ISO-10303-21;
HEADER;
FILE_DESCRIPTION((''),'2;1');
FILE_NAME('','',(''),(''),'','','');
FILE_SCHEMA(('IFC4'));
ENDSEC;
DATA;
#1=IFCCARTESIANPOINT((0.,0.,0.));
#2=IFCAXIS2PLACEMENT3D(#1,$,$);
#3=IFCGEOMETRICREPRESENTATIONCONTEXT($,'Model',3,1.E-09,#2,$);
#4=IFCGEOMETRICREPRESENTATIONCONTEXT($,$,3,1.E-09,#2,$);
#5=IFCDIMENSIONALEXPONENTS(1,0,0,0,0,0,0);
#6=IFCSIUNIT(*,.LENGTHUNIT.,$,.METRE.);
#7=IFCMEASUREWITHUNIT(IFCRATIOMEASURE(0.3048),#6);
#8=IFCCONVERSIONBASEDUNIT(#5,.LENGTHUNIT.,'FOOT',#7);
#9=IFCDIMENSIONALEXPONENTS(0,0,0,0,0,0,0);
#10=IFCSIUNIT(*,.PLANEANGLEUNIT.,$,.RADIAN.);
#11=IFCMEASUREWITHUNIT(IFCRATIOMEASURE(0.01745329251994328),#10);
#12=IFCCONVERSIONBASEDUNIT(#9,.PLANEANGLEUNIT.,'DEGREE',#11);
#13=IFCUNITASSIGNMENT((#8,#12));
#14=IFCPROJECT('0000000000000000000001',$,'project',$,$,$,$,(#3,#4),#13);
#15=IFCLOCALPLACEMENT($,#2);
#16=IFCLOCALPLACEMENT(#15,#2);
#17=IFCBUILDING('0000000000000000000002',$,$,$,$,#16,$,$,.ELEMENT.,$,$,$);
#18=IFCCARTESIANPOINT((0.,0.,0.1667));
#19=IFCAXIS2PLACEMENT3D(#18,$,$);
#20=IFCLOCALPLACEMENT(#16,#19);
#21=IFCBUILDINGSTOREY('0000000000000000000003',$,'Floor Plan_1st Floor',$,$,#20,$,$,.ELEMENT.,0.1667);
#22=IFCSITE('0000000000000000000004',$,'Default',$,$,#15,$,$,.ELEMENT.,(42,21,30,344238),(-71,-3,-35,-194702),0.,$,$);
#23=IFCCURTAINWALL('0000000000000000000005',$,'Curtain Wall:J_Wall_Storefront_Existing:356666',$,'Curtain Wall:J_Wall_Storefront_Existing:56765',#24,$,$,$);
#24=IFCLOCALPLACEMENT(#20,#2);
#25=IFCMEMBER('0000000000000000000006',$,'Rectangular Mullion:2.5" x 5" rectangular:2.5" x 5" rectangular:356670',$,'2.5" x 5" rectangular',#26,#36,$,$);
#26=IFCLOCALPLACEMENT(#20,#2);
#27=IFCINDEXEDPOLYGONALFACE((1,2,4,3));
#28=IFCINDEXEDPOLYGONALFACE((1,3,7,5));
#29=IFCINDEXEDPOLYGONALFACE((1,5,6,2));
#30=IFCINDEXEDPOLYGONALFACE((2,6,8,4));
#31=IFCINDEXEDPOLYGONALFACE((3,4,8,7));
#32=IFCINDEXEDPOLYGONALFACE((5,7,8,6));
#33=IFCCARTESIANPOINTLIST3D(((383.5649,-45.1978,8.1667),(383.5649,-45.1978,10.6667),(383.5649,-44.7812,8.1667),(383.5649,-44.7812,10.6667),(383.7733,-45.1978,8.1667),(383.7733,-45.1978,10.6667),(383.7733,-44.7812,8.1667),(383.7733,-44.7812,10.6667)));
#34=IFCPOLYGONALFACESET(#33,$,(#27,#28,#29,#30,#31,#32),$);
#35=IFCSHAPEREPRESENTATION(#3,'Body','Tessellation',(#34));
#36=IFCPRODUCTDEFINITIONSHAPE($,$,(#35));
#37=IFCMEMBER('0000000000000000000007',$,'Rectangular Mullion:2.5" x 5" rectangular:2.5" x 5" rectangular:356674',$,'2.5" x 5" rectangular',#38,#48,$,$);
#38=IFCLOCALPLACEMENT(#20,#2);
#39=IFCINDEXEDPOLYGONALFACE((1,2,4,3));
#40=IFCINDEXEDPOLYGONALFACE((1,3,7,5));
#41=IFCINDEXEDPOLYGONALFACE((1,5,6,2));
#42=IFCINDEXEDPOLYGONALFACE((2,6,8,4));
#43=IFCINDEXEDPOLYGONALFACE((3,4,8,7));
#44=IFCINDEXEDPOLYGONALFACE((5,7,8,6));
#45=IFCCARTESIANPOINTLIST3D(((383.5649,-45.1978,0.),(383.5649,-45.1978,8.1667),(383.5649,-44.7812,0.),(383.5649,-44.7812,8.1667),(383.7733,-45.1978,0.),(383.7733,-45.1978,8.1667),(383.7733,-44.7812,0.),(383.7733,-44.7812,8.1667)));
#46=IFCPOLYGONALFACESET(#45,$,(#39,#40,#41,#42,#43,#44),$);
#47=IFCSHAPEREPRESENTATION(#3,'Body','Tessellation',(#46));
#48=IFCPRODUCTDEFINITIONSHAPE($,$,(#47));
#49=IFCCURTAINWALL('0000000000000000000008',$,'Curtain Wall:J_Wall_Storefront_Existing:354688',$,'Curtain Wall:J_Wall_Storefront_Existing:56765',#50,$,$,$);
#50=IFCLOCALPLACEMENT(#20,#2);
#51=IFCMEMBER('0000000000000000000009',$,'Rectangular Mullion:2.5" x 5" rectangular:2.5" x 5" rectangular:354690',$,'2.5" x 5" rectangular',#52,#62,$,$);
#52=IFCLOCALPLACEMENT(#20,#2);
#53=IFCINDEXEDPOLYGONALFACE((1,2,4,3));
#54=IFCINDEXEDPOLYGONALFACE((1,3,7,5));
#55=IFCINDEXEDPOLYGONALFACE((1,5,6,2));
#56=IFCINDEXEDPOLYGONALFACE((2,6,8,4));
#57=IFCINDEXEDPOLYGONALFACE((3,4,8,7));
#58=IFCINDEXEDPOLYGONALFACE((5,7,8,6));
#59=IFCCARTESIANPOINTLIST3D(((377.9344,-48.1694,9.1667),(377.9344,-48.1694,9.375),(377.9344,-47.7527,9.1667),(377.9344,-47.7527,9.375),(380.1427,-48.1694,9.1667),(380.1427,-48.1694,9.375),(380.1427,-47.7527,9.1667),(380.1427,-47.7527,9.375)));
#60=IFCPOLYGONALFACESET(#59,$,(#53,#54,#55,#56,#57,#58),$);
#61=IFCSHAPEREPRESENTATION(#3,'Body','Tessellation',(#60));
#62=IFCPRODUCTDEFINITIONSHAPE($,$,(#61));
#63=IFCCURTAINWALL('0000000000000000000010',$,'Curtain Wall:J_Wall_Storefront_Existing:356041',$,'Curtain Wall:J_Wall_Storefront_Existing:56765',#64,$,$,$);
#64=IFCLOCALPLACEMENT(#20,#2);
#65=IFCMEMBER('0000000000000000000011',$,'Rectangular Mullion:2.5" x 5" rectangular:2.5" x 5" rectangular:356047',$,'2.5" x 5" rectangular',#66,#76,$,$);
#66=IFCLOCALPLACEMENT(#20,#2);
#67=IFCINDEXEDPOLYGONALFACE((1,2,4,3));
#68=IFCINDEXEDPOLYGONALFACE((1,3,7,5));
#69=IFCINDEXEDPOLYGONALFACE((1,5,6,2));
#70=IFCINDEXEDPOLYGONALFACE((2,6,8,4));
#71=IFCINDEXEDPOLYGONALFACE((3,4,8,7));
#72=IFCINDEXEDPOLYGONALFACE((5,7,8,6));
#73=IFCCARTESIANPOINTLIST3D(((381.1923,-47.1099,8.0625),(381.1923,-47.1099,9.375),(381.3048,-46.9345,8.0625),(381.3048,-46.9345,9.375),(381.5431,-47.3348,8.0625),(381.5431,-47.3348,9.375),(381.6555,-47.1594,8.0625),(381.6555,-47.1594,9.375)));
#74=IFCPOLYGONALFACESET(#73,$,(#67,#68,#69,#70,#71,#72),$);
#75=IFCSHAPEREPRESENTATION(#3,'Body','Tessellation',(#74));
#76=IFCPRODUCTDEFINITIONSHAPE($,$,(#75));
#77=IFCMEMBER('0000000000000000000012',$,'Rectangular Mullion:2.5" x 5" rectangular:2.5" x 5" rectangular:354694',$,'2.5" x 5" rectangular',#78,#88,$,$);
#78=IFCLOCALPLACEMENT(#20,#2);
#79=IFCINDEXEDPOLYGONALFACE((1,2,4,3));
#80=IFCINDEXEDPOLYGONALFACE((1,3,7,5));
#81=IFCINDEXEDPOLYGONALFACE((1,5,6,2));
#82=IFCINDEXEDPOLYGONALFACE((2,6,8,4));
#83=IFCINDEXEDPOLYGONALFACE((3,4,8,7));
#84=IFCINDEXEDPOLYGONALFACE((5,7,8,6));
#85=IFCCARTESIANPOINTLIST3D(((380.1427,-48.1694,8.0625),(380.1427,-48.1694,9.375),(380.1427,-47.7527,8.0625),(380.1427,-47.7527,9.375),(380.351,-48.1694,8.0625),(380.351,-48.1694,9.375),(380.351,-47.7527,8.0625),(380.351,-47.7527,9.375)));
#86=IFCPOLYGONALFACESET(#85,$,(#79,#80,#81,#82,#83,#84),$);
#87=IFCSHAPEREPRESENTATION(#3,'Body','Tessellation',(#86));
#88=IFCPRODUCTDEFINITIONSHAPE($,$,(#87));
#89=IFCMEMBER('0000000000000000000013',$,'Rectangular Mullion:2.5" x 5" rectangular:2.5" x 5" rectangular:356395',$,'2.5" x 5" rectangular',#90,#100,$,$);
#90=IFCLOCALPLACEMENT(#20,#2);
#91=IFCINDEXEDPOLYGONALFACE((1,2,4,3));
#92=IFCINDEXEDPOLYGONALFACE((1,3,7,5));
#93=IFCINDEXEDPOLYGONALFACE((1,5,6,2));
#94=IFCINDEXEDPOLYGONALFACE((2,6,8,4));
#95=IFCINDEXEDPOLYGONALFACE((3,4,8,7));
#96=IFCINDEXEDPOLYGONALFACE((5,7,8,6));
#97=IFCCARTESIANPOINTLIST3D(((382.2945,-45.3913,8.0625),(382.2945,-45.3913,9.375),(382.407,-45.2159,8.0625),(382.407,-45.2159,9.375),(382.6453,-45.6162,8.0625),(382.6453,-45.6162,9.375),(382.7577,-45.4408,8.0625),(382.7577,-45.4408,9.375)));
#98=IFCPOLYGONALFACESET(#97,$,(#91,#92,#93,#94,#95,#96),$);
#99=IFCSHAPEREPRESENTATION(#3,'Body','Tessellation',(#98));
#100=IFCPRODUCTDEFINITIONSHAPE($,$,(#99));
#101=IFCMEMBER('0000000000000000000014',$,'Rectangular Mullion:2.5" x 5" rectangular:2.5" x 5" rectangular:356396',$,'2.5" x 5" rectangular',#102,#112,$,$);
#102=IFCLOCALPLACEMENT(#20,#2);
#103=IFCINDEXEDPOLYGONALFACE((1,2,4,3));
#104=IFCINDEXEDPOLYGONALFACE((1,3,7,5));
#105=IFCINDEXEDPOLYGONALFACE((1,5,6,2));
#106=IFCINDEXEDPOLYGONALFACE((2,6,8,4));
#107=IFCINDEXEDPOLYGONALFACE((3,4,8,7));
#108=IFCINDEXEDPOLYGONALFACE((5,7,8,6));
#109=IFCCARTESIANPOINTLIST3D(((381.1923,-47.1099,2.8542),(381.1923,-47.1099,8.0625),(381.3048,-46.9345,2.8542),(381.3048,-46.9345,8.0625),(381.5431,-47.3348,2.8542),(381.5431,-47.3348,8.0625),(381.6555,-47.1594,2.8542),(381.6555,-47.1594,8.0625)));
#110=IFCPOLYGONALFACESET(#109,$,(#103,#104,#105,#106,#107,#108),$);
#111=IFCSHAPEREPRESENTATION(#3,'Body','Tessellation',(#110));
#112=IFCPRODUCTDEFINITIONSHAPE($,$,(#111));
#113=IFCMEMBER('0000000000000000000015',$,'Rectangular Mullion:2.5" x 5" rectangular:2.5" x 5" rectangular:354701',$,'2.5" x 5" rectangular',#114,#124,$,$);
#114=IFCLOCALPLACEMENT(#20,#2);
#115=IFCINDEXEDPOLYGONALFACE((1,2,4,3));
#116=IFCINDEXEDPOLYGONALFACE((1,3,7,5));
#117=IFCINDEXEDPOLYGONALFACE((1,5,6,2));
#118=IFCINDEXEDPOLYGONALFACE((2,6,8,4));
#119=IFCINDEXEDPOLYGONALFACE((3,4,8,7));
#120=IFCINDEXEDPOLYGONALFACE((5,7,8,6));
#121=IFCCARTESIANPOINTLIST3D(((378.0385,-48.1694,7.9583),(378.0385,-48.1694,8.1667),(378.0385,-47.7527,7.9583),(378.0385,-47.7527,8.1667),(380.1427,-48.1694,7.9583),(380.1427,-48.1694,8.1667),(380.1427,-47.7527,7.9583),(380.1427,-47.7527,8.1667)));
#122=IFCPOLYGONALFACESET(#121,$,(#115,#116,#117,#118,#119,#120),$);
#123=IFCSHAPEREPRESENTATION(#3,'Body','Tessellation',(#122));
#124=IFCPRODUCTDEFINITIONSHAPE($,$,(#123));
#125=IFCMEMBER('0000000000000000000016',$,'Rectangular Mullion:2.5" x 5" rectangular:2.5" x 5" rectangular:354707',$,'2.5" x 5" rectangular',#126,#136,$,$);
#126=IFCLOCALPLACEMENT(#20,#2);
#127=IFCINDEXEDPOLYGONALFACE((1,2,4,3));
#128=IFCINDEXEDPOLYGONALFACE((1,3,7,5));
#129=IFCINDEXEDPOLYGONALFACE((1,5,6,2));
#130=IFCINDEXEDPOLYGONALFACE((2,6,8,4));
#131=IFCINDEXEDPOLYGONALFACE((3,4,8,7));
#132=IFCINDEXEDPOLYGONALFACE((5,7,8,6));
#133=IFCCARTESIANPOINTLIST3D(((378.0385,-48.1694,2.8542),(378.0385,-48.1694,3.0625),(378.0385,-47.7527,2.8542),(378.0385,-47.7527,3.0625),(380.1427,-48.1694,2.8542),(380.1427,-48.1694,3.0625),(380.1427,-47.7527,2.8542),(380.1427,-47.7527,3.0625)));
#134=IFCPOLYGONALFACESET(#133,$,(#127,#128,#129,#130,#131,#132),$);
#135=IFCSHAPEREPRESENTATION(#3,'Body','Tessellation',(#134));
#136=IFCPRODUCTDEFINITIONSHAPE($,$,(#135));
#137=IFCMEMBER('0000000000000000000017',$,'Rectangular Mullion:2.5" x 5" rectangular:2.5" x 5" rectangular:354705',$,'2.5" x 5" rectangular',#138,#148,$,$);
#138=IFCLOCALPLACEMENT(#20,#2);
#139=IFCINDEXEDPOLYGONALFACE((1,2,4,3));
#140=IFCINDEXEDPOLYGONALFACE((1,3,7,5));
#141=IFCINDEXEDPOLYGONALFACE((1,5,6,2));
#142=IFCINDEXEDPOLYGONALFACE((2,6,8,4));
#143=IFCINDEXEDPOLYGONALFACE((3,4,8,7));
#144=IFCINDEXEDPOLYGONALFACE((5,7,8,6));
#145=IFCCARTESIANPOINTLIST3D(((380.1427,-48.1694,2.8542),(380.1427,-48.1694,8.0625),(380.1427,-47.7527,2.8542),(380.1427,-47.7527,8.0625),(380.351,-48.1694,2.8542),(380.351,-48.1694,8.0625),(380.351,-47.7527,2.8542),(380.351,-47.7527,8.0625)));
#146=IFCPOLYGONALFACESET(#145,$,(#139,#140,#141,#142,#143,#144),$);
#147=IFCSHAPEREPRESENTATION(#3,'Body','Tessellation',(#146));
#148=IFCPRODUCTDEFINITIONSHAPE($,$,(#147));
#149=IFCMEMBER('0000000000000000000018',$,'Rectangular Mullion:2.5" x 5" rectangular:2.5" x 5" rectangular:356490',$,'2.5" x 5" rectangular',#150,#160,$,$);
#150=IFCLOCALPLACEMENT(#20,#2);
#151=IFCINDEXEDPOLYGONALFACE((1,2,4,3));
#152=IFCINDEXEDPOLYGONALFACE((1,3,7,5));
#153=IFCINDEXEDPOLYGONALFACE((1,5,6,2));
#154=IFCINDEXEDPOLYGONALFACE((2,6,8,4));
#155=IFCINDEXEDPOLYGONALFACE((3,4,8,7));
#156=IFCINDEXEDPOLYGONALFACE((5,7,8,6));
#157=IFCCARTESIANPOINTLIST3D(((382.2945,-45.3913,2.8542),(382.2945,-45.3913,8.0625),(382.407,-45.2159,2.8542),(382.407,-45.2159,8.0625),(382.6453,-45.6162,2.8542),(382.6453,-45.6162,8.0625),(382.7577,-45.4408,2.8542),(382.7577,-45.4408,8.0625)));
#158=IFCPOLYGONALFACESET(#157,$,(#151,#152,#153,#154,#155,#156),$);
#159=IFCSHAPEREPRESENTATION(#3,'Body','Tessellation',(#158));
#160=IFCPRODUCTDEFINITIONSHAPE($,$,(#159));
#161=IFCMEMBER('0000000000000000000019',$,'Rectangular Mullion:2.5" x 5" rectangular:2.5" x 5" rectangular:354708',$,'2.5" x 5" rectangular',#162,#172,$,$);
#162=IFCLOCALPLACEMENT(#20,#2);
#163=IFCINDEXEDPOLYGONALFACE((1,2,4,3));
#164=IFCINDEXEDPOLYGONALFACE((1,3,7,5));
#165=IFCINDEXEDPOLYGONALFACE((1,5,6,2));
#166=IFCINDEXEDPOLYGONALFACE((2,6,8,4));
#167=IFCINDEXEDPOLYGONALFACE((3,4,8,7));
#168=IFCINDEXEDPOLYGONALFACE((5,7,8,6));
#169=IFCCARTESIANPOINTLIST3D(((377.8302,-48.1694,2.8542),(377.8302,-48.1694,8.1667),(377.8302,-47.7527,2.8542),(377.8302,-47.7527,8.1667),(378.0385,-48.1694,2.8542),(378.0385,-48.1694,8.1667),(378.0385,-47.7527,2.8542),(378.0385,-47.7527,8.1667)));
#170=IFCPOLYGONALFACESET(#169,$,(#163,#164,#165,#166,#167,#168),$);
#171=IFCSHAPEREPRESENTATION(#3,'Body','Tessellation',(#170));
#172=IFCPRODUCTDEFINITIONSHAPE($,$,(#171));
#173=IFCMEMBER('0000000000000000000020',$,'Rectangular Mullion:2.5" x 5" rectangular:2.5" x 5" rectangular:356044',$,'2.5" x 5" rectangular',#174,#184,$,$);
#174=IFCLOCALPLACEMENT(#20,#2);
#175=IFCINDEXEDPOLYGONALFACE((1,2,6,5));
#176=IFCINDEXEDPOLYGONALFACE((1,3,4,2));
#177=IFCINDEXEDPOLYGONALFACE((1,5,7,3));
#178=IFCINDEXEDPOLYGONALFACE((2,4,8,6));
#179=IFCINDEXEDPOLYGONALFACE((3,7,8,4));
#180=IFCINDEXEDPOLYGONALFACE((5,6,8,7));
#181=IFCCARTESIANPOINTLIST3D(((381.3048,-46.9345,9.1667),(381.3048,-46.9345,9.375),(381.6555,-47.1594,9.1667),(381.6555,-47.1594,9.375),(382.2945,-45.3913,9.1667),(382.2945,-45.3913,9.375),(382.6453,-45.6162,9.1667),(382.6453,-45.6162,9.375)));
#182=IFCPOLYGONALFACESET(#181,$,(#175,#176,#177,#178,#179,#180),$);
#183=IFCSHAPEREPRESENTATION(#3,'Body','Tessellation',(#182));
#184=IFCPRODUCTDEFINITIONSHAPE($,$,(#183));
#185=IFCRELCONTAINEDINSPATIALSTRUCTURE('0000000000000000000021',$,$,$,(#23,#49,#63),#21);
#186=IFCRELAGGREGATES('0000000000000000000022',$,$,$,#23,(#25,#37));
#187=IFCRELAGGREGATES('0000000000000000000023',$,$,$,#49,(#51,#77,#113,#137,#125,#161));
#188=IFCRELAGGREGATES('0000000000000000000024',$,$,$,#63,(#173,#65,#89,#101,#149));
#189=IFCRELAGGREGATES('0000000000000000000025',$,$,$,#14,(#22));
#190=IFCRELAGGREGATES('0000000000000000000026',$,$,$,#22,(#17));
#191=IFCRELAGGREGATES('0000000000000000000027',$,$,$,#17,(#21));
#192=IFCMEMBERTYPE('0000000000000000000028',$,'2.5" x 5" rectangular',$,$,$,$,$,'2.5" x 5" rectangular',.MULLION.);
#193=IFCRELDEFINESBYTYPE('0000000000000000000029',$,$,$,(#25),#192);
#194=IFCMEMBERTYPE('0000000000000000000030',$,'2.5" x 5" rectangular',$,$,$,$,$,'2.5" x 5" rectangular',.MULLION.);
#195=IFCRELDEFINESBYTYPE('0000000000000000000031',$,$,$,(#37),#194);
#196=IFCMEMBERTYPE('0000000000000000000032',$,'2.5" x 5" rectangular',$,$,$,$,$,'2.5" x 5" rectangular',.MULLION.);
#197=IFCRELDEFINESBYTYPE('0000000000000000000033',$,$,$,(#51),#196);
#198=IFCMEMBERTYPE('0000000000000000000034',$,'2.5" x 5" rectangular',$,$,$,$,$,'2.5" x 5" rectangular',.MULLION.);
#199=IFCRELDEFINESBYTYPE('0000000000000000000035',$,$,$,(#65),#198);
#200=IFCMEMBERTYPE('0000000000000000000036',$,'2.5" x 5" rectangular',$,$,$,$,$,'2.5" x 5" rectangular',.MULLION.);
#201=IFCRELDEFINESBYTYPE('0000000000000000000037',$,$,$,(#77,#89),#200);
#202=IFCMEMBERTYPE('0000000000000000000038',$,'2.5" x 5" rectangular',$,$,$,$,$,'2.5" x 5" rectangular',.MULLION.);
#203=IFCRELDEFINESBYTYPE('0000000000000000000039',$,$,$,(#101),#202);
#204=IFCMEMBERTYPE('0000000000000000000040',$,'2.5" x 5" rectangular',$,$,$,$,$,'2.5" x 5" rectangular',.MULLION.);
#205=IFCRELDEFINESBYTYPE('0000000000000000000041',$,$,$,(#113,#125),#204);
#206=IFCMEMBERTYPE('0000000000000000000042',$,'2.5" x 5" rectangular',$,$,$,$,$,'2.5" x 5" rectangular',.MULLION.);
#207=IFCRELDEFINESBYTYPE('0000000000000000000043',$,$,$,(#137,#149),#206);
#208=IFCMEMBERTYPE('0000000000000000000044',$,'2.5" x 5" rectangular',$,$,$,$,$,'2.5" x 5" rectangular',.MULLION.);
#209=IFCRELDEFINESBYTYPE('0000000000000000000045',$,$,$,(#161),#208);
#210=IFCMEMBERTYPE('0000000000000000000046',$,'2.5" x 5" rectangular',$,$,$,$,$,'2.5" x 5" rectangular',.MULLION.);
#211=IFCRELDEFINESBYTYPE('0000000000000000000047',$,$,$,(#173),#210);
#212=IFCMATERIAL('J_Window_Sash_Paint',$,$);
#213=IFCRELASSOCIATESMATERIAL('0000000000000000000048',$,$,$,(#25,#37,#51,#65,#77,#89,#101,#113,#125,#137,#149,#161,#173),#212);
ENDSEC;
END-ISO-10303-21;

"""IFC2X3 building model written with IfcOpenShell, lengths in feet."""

from ifc_helpers import new_model, entity, si_unit, converted_unit, frame, origin, origin_2d_with_axis, place, context, project, spatial, rectangle, extrude, source, transform, mapped, material, type_object, type_shapes, element, aggregate, save


model = new_model("IFC2X3")

# Units and contexts
model_context = context("Model", 3, precision=1e-09, world=origin())
context_of_model = context(None, 3, precision=1e-09, world=origin())
ifc_project = project(units=[converted_unit("LENGTHUNIT", "FOOT", entity("IfcRatioMeasure", 0.3048), si_unit("LENGTHUNIT", "METRE"), dimensions=[1, 0, 0, 0, 0, 0, 0]), converted_unit("PLANEANGLEUNIT", "DEGREE", entity("IfcRatioMeasure", 0.01745329251994328), si_unit("PLANEANGLEUNIT", "RADIAN"), dimensions=[0, 0, 0, 0, 0, 0, 0])], contexts=[model_context, context_of_model])

# Site, building, storey
site_placement = place(None, origin())
site = spatial("IfcSite", under=ifc_project, at=site_placement, Name="Default", CompositionType="ELEMENT", RefLatitude=(42, 21, 30, 344238), RefLongitude=(-71, -3, -35, -194702), RefElevation=0.0)
building_placement = place(site_placement, origin())
building = spatial("IfcBuilding", under=site, at=building_placement, CompositionType="ELEMENT")
storey_placement = place(building_placement, frame((0.0, 0.0, 0.1667)))
storey = spatial("IfcBuildingStorey", under=building, at=storey_placement, Name="Floor Plan_1st Floor", CompositionType="ELEMENT", Elevation=0.1667)

# Curtain wall, members
curtain_wall_1_placement = place(storey_placement, origin())
curtain_wall_1 = element("IfcCurtainWall", 1, at=curtain_wall_1_placement, inside=storey, Name="Curtain Wall:J_Wall_Storefront_Existing:356666", ObjectType="Curtain Wall:J_Wall_Storefront_Existing:56765")
ifc_material_1 = material(Name="J_Window_Sash_Paint")
member_type_1 = type_object("IfcMemberType", Name="2.5\" x 5\" rectangular", ElementType="2.5\" x 5\" rectangular", PredefinedType="MULLION")
shared_shape_1 = source(origin(), model_context, "Body", "SweptSolid", [
    extrude(rectangle(XDim=0.2083, YDim=0.4167, at=origin_2d_with_axis()), frame((-0.1042, 0.0, -2.5), z_axis=(0.0, 0.0, 1.0), x_axis=(-1.0, 0.0, 0.0)), (0.0, 0.0, 1.0), 2.5),
])
type_shapes(member_type_1, [shared_shape_1])
member_1_placement = place(storey_placement, frame((383.5649, -44.9895, 10.6667), z_axis=(0.0, 0.0, 1.0), x_axis=(-1.0, 0.0, 0.0)))
member_1 = element("IfcMember", 2, at=member_1_placement, type_object=member_type_1, material=ifc_material_1, Name="Rectangular Mullion:2.5\" x 5\" rectangular:2.5\" x 5\" rectangular:356670", ObjectType="2.5\" x 5\" rectangular", context=model_context, shape_type="MappedRepresentation", body=[
    mapped(shared_shape_1, transform((0.0, 0.0, 0.0), scale=1.0)),
])
member_type_2 = type_object("IfcMemberType", Name="2.5\" x 5\" rectangular", ElementType="2.5\" x 5\" rectangular", PredefinedType="MULLION")
shared_shape_2 = source(origin(), model_context, "Body", "SweptSolid", [
    extrude(rectangle(XDim=0.2083, YDim=0.4167, at=origin_2d_with_axis()), frame((-0.1042, 0.0, -8.1667), z_axis=(0.0, 0.0, 1.0), x_axis=(-1.0, 0.0, 0.0)), (0.0, 0.0, 1.0), 8.1667),
])
type_shapes(member_type_2, [shared_shape_2])
member_2_placement = place(storey_placement, frame((383.5649, -44.9895, 8.1667), z_axis=(0.0, 0.0, 1.0), x_axis=(-1.0, 0.0, 0.0)))
member_2 = element("IfcMember", 3, at=member_2_placement, type_object=member_type_2, material=ifc_material_1, Name="Rectangular Mullion:2.5\" x 5\" rectangular:2.5\" x 5\" rectangular:356674", ObjectType="2.5\" x 5\" rectangular", context=model_context, shape_type="MappedRepresentation", body=[
    mapped(shared_shape_2, transform((0.0, 0.0, 0.0), scale=1.0)),
])
aggregate(curtain_wall_1, [member_1, member_2])

# Curtain walls, members
curtain_wall_2_placement = place(storey_placement, origin())
curtain_wall_2 = element("IfcCurtainWall", 4, at=curtain_wall_2_placement, inside=storey, Name="Curtain Wall:J_Wall_Storefront_Existing:354688", ObjectType="Curtain Wall:J_Wall_Storefront_Existing:56765")
member_type_3 = type_object("IfcMemberType", Name="2.5\" x 5\" rectangular", ElementType="2.5\" x 5\" rectangular", PredefinedType="MULLION")
shared_shape_3 = source(origin(), model_context, "Body", "SweptSolid", [
    extrude(rectangle(XDim=0.2083, YDim=0.4167, at=origin_2d_with_axis()), frame((-0.1042, 0.0, -2.2083), z_axis=(0.0, 0.0, 1.0), x_axis=(-1.0, 0.0, 0.0)), (0.0, 0.0, 1.0), 2.2083),
])
type_shapes(member_type_3, [shared_shape_3])
member_3_placement = place(storey_placement, frame((380.1427, -47.9611, 9.375), z_axis=(1.0, 0.0, 0.0), x_axis=(0.0, 0.0, 1.0)))
member_3 = element("IfcMember", 5, at=member_3_placement, type_object=member_type_3, material=ifc_material_1, Name="Rectangular Mullion:2.5\" x 5\" rectangular:2.5\" x 5\" rectangular:354690", ObjectType="2.5\" x 5\" rectangular", context=model_context, shape_type="MappedRepresentation", body=[
    mapped(shared_shape_3, transform((0.0, 0.0, 0.0), scale=1.0)),
])
curtain_wall_3_placement = place(storey_placement, origin())
curtain_wall_3 = element("IfcCurtainWall", 6, at=curtain_wall_3_placement, inside=storey, Name="Curtain Wall:J_Wall_Storefront_Existing:356041", ObjectType="Curtain Wall:J_Wall_Storefront_Existing:56765")
member_type_4 = type_object("IfcMemberType", Name="2.5\" x 5\" rectangular", ElementType="2.5\" x 5\" rectangular", PredefinedType="MULLION")
shared_shape_4 = source(origin(), model_context, "Body", "SweptSolid", [
    extrude(rectangle(XDim=0.2083, YDim=0.4167, at=origin_2d_with_axis()), frame((-0.1042, 0.0, -1.3125), z_axis=(0.0, 0.0, 1.0), x_axis=(-1.0, 0.0, 0.0)), (0.0, 0.0, 1.0), 1.3125),
])
type_shapes(member_type_4, [shared_shape_4])
member_4_placement = place(storey_placement, frame((381.3677, -47.2223, 9.375), z_axis=(0.0, 0.0, 1.0), x_axis=(-0.539846, -0.841764, 0.0)))
member_4 = element("IfcMember", 7, at=member_4_placement, type_object=member_type_4, material=ifc_material_1, Name="Rectangular Mullion:2.5\" x 5\" rectangular:2.5\" x 5\" rectangular:356047", ObjectType="2.5\" x 5\" rectangular", context=model_context, shape_type="MappedRepresentation", body=[
    mapped(shared_shape_4, transform((0.0, 0.0, 0.0), scale=1.0)),
])

# Members
member_type_5 = type_object("IfcMemberType", Name="2.5\" x 5\" rectangular", ElementType="2.5\" x 5\" rectangular", PredefinedType="MULLION")
shared_shape_5 = source(origin(), model_context, "Body", "SweptSolid", [
    extrude(rectangle(XDim=0.2083, YDim=0.4167, at=origin_2d_with_axis()), frame((-0.1042, 0.0, -1.3125), z_axis=(0.0, 0.0, 1.0), x_axis=(-1.0, 0.0, 0.0)), (0.0, 0.0, 1.0), 1.3125),
])
type_shapes(member_type_5, [shared_shape_5])
member_5_placement = place(storey_placement, frame((380.351, -47.9611, 8.0625), z_axis=(0.0, 0.0, -1.0), x_axis=(1.0, 0.0, 0.0)))
member_5 = element("IfcMember", 8, at=member_5_placement, type_object=member_type_5, material=ifc_material_1, Name="Rectangular Mullion:2.5\" x 5\" rectangular:2.5\" x 5\" rectangular:354694", ObjectType="2.5\" x 5\" rectangular", context=model_context, shape_type="MappedRepresentation", body=[
    mapped(shared_shape_5, transform((0.0, 0.0, 0.0), scale=1.0)),
])
member_6_placement = place(storey_placement, frame((382.5824, -45.3284, 8.0625), z_axis=(0.0, 0.0, -1.0), x_axis=(0.539846, 0.841764, 0.0)))
member_6 = element("IfcMember", 9, at=member_6_placement, type_object=member_type_5, material=ifc_material_1, Name="Rectangular Mullion:2.5\" x 5\" rectangular:2.5\" x 5\" rectangular:356395", ObjectType="2.5\" x 5\" rectangular", context=model_context, shape_type="MappedRepresentation", body=[
    mapped(shared_shape_5, transform((0.0, 0.0, 0.0), scale=1.0)),
])
member_type_6 = type_object("IfcMemberType", Name="2.5\" x 5\" rectangular", ElementType="2.5\" x 5\" rectangular", PredefinedType="MULLION")
shared_shape_6 = source(origin(), model_context, "Body", "SweptSolid", [
    extrude(rectangle(XDim=0.2083, YDim=0.4167, at=origin_2d_with_axis()), frame((-0.1042, 0.0, -5.2083), z_axis=(0.0, 0.0, 1.0), x_axis=(-1.0, 0.0, 0.0)), (0.0, 0.0, 1.0), 5.2083),
])
type_shapes(member_type_6, [shared_shape_6])
member_7_placement = place(storey_placement, frame((381.3677, -47.2223, 8.0625), z_axis=(0.0, 0.0, 1.0), x_axis=(-0.539846, -0.841764, 0.0)))
member_7 = element("IfcMember", 10, at=member_7_placement, type_object=member_type_6, material=ifc_material_1, Name="Rectangular Mullion:2.5\" x 5\" rectangular:2.5\" x 5\" rectangular:356396", ObjectType="2.5\" x 5\" rectangular", context=model_context, shape_type="MappedRepresentation", body=[
    mapped(shared_shape_6, transform((0.0, 0.0, 0.0), scale=1.0)),
])
member_type_7 = type_object("IfcMemberType", Name="2.5\" x 5\" rectangular", ElementType="2.5\" x 5\" rectangular", PredefinedType="MULLION")
shared_shape_7 = source(origin(), model_context, "Body", "SweptSolid", [
    extrude(rectangle(XDim=0.2083, YDim=0.4167, at=origin_2d_with_axis()), frame((0.0, 0.0, -2.1042), z_axis=(0.0, 0.0, 1.0), x_axis=(-1.0, 0.0, 0.0)), (0.0, 0.0, 1.0), 2.1042),
])
type_shapes(member_type_7, [shared_shape_7])
member_8_placement = place(storey_placement, frame((380.1427, -47.9611, 8.0625), z_axis=(1.0, 0.0, 0.0), x_axis=(0.0, 0.0, 1.0)))
member_8 = element("IfcMember", 11, at=member_8_placement, type_object=member_type_7, material=ifc_material_1, Name="Rectangular Mullion:2.5\" x 5\" rectangular:2.5\" x 5\" rectangular:354701", ObjectType="2.5\" x 5\" rectangular", context=model_context, shape_type="MappedRepresentation", body=[
    mapped(shared_shape_7, transform((0.0, 0.0, 0.0), scale=1.0)),
])
member_9_placement = place(storey_placement, frame((380.1427, -47.9611, 2.9583), z_axis=(1.0, 0.0, 0.0), x_axis=(0.0, 0.0, 1.0)))
member_9 = element("IfcMember", 12, at=member_9_placement, type_object=member_type_7, material=ifc_material_1, Name="Rectangular Mullion:2.5\" x 5\" rectangular:2.5\" x 5\" rectangular:354707", ObjectType="2.5\" x 5\" rectangular", context=model_context, shape_type="MappedRepresentation", body=[
    mapped(shared_shape_7, transform((0.0, 0.0, 0.0), scale=1.0)),
])
member_type_8 = type_object("IfcMemberType", Name="2.5\" x 5\" rectangular", ElementType="2.5\" x 5\" rectangular", PredefinedType="MULLION")
shared_shape_8 = source(origin(), model_context, "Body", "SweptSolid", [
    extrude(rectangle(XDim=0.2083, YDim=0.4167, at=origin_2d_with_axis()), frame((-0.1042, 0.0, -5.2083), z_axis=(0.0, 0.0, 1.0), x_axis=(-1.0, 0.0, 0.0)), (0.0, 0.0, 1.0), 5.2083),
])
type_shapes(member_type_8, [shared_shape_8])
member_10_placement = place(storey_placement, frame((380.351, -47.9611, 2.8542), z_axis=(0.0, 0.0, -1.0), x_axis=(1.0, 0.0, 0.0)))
member_10 = element("IfcMember", 13, at=member_10_placement, type_object=member_type_8, material=ifc_material_1, Name="Rectangular Mullion:2.5\" x 5\" rectangular:2.5\" x 5\" rectangular:354705", ObjectType="2.5\" x 5\" rectangular", context=model_context, shape_type="MappedRepresentation", body=[
    mapped(shared_shape_8, transform((0.0, 0.0, 0.0), scale=1.0)),
])
member_11_placement = place(storey_placement, frame((382.5824, -45.3284, 2.8542), z_axis=(0.0, 0.0, -1.0), x_axis=(0.539846, 0.841764, 0.0)))
member_11 = element("IfcMember", 14, at=member_11_placement, type_object=member_type_8, material=ifc_material_1, Name="Rectangular Mullion:2.5\" x 5\" rectangular:2.5\" x 5\" rectangular:356490", ObjectType="2.5\" x 5\" rectangular", context=model_context, shape_type="MappedRepresentation", body=[
    mapped(shared_shape_8, transform((0.0, 0.0, 0.0), scale=1.0)),
])
member_type_9 = type_object("IfcMemberType", Name="2.5\" x 5\" rectangular", ElementType="2.5\" x 5\" rectangular", PredefinedType="MULLION")
shared_shape_9 = source(origin(), model_context, "Body", "SweptSolid", [
    extrude(rectangle(XDim=0.2083, YDim=0.4167, at=origin_2d_with_axis()), frame((0.0, 0.0, -5.3125), z_axis=(0.0, 0.0, 1.0), x_axis=(-1.0, 0.0, 0.0)), (0.0, 0.0, 1.0), 5.3125),
])
type_shapes(member_type_9, [shared_shape_9])
member_12_placement = place(storey_placement, frame((377.9344, -47.9611, 2.8542), z_axis=(0.0, 0.0, -1.0), x_axis=(1.0, 0.0, 0.0)))
member_12 = element("IfcMember", 15, at=member_12_placement, type_object=member_type_9, material=ifc_material_1, Name="Rectangular Mullion:2.5\" x 5\" rectangular:2.5\" x 5\" rectangular:354708", ObjectType="2.5\" x 5\" rectangular", context=model_context, shape_type="MappedRepresentation", body=[
    mapped(shared_shape_9, transform((0.0, 0.0, 0.0), scale=1.0)),
])
member_type_10 = type_object("IfcMemberType", Name="2.5\" x 5\" rectangular", ElementType="2.5\" x 5\" rectangular", PredefinedType="MULLION")
shared_shape_10 = source(origin(), model_context, "Body", "SweptSolid", [
    extrude(rectangle(XDim=0.2083, YDim=0.4167, at=origin_2d_with_axis()), frame((-0.1042, 0.0, -1.8333), z_axis=(0.0, 0.0, 1.0), x_axis=(-1.0, 0.0, 0.0)), (0.0, 0.0, 1.0), 1.8333),
])
type_shapes(member_type_10, [shared_shape_10])
member_13_placement = place(storey_placement, frame((382.4699, -45.5037, 9.375), z_axis=(0.539846, 0.841764, 0.0), x_axis=(0.0, 0.0, 1.0)))
member_13 = element("IfcMember", 16, at=member_13_placement, type_object=member_type_10, material=ifc_material_1, Name="Rectangular Mullion:2.5\" x 5\" rectangular:2.5\" x 5\" rectangular:356044", ObjectType="2.5\" x 5\" rectangular", context=model_context, shape_type="MappedRepresentation", body=[
    mapped(shared_shape_10, transform((0.0, 0.0, 0.0), scale=1.0)),
])

aggregate(curtain_wall_2, [member_3, member_5, member_8, member_10, member_9, member_12])
aggregate(curtain_wall_3, [member_13, member_4, member_6, member_7, member_11])

save(model, "model.ifc")
